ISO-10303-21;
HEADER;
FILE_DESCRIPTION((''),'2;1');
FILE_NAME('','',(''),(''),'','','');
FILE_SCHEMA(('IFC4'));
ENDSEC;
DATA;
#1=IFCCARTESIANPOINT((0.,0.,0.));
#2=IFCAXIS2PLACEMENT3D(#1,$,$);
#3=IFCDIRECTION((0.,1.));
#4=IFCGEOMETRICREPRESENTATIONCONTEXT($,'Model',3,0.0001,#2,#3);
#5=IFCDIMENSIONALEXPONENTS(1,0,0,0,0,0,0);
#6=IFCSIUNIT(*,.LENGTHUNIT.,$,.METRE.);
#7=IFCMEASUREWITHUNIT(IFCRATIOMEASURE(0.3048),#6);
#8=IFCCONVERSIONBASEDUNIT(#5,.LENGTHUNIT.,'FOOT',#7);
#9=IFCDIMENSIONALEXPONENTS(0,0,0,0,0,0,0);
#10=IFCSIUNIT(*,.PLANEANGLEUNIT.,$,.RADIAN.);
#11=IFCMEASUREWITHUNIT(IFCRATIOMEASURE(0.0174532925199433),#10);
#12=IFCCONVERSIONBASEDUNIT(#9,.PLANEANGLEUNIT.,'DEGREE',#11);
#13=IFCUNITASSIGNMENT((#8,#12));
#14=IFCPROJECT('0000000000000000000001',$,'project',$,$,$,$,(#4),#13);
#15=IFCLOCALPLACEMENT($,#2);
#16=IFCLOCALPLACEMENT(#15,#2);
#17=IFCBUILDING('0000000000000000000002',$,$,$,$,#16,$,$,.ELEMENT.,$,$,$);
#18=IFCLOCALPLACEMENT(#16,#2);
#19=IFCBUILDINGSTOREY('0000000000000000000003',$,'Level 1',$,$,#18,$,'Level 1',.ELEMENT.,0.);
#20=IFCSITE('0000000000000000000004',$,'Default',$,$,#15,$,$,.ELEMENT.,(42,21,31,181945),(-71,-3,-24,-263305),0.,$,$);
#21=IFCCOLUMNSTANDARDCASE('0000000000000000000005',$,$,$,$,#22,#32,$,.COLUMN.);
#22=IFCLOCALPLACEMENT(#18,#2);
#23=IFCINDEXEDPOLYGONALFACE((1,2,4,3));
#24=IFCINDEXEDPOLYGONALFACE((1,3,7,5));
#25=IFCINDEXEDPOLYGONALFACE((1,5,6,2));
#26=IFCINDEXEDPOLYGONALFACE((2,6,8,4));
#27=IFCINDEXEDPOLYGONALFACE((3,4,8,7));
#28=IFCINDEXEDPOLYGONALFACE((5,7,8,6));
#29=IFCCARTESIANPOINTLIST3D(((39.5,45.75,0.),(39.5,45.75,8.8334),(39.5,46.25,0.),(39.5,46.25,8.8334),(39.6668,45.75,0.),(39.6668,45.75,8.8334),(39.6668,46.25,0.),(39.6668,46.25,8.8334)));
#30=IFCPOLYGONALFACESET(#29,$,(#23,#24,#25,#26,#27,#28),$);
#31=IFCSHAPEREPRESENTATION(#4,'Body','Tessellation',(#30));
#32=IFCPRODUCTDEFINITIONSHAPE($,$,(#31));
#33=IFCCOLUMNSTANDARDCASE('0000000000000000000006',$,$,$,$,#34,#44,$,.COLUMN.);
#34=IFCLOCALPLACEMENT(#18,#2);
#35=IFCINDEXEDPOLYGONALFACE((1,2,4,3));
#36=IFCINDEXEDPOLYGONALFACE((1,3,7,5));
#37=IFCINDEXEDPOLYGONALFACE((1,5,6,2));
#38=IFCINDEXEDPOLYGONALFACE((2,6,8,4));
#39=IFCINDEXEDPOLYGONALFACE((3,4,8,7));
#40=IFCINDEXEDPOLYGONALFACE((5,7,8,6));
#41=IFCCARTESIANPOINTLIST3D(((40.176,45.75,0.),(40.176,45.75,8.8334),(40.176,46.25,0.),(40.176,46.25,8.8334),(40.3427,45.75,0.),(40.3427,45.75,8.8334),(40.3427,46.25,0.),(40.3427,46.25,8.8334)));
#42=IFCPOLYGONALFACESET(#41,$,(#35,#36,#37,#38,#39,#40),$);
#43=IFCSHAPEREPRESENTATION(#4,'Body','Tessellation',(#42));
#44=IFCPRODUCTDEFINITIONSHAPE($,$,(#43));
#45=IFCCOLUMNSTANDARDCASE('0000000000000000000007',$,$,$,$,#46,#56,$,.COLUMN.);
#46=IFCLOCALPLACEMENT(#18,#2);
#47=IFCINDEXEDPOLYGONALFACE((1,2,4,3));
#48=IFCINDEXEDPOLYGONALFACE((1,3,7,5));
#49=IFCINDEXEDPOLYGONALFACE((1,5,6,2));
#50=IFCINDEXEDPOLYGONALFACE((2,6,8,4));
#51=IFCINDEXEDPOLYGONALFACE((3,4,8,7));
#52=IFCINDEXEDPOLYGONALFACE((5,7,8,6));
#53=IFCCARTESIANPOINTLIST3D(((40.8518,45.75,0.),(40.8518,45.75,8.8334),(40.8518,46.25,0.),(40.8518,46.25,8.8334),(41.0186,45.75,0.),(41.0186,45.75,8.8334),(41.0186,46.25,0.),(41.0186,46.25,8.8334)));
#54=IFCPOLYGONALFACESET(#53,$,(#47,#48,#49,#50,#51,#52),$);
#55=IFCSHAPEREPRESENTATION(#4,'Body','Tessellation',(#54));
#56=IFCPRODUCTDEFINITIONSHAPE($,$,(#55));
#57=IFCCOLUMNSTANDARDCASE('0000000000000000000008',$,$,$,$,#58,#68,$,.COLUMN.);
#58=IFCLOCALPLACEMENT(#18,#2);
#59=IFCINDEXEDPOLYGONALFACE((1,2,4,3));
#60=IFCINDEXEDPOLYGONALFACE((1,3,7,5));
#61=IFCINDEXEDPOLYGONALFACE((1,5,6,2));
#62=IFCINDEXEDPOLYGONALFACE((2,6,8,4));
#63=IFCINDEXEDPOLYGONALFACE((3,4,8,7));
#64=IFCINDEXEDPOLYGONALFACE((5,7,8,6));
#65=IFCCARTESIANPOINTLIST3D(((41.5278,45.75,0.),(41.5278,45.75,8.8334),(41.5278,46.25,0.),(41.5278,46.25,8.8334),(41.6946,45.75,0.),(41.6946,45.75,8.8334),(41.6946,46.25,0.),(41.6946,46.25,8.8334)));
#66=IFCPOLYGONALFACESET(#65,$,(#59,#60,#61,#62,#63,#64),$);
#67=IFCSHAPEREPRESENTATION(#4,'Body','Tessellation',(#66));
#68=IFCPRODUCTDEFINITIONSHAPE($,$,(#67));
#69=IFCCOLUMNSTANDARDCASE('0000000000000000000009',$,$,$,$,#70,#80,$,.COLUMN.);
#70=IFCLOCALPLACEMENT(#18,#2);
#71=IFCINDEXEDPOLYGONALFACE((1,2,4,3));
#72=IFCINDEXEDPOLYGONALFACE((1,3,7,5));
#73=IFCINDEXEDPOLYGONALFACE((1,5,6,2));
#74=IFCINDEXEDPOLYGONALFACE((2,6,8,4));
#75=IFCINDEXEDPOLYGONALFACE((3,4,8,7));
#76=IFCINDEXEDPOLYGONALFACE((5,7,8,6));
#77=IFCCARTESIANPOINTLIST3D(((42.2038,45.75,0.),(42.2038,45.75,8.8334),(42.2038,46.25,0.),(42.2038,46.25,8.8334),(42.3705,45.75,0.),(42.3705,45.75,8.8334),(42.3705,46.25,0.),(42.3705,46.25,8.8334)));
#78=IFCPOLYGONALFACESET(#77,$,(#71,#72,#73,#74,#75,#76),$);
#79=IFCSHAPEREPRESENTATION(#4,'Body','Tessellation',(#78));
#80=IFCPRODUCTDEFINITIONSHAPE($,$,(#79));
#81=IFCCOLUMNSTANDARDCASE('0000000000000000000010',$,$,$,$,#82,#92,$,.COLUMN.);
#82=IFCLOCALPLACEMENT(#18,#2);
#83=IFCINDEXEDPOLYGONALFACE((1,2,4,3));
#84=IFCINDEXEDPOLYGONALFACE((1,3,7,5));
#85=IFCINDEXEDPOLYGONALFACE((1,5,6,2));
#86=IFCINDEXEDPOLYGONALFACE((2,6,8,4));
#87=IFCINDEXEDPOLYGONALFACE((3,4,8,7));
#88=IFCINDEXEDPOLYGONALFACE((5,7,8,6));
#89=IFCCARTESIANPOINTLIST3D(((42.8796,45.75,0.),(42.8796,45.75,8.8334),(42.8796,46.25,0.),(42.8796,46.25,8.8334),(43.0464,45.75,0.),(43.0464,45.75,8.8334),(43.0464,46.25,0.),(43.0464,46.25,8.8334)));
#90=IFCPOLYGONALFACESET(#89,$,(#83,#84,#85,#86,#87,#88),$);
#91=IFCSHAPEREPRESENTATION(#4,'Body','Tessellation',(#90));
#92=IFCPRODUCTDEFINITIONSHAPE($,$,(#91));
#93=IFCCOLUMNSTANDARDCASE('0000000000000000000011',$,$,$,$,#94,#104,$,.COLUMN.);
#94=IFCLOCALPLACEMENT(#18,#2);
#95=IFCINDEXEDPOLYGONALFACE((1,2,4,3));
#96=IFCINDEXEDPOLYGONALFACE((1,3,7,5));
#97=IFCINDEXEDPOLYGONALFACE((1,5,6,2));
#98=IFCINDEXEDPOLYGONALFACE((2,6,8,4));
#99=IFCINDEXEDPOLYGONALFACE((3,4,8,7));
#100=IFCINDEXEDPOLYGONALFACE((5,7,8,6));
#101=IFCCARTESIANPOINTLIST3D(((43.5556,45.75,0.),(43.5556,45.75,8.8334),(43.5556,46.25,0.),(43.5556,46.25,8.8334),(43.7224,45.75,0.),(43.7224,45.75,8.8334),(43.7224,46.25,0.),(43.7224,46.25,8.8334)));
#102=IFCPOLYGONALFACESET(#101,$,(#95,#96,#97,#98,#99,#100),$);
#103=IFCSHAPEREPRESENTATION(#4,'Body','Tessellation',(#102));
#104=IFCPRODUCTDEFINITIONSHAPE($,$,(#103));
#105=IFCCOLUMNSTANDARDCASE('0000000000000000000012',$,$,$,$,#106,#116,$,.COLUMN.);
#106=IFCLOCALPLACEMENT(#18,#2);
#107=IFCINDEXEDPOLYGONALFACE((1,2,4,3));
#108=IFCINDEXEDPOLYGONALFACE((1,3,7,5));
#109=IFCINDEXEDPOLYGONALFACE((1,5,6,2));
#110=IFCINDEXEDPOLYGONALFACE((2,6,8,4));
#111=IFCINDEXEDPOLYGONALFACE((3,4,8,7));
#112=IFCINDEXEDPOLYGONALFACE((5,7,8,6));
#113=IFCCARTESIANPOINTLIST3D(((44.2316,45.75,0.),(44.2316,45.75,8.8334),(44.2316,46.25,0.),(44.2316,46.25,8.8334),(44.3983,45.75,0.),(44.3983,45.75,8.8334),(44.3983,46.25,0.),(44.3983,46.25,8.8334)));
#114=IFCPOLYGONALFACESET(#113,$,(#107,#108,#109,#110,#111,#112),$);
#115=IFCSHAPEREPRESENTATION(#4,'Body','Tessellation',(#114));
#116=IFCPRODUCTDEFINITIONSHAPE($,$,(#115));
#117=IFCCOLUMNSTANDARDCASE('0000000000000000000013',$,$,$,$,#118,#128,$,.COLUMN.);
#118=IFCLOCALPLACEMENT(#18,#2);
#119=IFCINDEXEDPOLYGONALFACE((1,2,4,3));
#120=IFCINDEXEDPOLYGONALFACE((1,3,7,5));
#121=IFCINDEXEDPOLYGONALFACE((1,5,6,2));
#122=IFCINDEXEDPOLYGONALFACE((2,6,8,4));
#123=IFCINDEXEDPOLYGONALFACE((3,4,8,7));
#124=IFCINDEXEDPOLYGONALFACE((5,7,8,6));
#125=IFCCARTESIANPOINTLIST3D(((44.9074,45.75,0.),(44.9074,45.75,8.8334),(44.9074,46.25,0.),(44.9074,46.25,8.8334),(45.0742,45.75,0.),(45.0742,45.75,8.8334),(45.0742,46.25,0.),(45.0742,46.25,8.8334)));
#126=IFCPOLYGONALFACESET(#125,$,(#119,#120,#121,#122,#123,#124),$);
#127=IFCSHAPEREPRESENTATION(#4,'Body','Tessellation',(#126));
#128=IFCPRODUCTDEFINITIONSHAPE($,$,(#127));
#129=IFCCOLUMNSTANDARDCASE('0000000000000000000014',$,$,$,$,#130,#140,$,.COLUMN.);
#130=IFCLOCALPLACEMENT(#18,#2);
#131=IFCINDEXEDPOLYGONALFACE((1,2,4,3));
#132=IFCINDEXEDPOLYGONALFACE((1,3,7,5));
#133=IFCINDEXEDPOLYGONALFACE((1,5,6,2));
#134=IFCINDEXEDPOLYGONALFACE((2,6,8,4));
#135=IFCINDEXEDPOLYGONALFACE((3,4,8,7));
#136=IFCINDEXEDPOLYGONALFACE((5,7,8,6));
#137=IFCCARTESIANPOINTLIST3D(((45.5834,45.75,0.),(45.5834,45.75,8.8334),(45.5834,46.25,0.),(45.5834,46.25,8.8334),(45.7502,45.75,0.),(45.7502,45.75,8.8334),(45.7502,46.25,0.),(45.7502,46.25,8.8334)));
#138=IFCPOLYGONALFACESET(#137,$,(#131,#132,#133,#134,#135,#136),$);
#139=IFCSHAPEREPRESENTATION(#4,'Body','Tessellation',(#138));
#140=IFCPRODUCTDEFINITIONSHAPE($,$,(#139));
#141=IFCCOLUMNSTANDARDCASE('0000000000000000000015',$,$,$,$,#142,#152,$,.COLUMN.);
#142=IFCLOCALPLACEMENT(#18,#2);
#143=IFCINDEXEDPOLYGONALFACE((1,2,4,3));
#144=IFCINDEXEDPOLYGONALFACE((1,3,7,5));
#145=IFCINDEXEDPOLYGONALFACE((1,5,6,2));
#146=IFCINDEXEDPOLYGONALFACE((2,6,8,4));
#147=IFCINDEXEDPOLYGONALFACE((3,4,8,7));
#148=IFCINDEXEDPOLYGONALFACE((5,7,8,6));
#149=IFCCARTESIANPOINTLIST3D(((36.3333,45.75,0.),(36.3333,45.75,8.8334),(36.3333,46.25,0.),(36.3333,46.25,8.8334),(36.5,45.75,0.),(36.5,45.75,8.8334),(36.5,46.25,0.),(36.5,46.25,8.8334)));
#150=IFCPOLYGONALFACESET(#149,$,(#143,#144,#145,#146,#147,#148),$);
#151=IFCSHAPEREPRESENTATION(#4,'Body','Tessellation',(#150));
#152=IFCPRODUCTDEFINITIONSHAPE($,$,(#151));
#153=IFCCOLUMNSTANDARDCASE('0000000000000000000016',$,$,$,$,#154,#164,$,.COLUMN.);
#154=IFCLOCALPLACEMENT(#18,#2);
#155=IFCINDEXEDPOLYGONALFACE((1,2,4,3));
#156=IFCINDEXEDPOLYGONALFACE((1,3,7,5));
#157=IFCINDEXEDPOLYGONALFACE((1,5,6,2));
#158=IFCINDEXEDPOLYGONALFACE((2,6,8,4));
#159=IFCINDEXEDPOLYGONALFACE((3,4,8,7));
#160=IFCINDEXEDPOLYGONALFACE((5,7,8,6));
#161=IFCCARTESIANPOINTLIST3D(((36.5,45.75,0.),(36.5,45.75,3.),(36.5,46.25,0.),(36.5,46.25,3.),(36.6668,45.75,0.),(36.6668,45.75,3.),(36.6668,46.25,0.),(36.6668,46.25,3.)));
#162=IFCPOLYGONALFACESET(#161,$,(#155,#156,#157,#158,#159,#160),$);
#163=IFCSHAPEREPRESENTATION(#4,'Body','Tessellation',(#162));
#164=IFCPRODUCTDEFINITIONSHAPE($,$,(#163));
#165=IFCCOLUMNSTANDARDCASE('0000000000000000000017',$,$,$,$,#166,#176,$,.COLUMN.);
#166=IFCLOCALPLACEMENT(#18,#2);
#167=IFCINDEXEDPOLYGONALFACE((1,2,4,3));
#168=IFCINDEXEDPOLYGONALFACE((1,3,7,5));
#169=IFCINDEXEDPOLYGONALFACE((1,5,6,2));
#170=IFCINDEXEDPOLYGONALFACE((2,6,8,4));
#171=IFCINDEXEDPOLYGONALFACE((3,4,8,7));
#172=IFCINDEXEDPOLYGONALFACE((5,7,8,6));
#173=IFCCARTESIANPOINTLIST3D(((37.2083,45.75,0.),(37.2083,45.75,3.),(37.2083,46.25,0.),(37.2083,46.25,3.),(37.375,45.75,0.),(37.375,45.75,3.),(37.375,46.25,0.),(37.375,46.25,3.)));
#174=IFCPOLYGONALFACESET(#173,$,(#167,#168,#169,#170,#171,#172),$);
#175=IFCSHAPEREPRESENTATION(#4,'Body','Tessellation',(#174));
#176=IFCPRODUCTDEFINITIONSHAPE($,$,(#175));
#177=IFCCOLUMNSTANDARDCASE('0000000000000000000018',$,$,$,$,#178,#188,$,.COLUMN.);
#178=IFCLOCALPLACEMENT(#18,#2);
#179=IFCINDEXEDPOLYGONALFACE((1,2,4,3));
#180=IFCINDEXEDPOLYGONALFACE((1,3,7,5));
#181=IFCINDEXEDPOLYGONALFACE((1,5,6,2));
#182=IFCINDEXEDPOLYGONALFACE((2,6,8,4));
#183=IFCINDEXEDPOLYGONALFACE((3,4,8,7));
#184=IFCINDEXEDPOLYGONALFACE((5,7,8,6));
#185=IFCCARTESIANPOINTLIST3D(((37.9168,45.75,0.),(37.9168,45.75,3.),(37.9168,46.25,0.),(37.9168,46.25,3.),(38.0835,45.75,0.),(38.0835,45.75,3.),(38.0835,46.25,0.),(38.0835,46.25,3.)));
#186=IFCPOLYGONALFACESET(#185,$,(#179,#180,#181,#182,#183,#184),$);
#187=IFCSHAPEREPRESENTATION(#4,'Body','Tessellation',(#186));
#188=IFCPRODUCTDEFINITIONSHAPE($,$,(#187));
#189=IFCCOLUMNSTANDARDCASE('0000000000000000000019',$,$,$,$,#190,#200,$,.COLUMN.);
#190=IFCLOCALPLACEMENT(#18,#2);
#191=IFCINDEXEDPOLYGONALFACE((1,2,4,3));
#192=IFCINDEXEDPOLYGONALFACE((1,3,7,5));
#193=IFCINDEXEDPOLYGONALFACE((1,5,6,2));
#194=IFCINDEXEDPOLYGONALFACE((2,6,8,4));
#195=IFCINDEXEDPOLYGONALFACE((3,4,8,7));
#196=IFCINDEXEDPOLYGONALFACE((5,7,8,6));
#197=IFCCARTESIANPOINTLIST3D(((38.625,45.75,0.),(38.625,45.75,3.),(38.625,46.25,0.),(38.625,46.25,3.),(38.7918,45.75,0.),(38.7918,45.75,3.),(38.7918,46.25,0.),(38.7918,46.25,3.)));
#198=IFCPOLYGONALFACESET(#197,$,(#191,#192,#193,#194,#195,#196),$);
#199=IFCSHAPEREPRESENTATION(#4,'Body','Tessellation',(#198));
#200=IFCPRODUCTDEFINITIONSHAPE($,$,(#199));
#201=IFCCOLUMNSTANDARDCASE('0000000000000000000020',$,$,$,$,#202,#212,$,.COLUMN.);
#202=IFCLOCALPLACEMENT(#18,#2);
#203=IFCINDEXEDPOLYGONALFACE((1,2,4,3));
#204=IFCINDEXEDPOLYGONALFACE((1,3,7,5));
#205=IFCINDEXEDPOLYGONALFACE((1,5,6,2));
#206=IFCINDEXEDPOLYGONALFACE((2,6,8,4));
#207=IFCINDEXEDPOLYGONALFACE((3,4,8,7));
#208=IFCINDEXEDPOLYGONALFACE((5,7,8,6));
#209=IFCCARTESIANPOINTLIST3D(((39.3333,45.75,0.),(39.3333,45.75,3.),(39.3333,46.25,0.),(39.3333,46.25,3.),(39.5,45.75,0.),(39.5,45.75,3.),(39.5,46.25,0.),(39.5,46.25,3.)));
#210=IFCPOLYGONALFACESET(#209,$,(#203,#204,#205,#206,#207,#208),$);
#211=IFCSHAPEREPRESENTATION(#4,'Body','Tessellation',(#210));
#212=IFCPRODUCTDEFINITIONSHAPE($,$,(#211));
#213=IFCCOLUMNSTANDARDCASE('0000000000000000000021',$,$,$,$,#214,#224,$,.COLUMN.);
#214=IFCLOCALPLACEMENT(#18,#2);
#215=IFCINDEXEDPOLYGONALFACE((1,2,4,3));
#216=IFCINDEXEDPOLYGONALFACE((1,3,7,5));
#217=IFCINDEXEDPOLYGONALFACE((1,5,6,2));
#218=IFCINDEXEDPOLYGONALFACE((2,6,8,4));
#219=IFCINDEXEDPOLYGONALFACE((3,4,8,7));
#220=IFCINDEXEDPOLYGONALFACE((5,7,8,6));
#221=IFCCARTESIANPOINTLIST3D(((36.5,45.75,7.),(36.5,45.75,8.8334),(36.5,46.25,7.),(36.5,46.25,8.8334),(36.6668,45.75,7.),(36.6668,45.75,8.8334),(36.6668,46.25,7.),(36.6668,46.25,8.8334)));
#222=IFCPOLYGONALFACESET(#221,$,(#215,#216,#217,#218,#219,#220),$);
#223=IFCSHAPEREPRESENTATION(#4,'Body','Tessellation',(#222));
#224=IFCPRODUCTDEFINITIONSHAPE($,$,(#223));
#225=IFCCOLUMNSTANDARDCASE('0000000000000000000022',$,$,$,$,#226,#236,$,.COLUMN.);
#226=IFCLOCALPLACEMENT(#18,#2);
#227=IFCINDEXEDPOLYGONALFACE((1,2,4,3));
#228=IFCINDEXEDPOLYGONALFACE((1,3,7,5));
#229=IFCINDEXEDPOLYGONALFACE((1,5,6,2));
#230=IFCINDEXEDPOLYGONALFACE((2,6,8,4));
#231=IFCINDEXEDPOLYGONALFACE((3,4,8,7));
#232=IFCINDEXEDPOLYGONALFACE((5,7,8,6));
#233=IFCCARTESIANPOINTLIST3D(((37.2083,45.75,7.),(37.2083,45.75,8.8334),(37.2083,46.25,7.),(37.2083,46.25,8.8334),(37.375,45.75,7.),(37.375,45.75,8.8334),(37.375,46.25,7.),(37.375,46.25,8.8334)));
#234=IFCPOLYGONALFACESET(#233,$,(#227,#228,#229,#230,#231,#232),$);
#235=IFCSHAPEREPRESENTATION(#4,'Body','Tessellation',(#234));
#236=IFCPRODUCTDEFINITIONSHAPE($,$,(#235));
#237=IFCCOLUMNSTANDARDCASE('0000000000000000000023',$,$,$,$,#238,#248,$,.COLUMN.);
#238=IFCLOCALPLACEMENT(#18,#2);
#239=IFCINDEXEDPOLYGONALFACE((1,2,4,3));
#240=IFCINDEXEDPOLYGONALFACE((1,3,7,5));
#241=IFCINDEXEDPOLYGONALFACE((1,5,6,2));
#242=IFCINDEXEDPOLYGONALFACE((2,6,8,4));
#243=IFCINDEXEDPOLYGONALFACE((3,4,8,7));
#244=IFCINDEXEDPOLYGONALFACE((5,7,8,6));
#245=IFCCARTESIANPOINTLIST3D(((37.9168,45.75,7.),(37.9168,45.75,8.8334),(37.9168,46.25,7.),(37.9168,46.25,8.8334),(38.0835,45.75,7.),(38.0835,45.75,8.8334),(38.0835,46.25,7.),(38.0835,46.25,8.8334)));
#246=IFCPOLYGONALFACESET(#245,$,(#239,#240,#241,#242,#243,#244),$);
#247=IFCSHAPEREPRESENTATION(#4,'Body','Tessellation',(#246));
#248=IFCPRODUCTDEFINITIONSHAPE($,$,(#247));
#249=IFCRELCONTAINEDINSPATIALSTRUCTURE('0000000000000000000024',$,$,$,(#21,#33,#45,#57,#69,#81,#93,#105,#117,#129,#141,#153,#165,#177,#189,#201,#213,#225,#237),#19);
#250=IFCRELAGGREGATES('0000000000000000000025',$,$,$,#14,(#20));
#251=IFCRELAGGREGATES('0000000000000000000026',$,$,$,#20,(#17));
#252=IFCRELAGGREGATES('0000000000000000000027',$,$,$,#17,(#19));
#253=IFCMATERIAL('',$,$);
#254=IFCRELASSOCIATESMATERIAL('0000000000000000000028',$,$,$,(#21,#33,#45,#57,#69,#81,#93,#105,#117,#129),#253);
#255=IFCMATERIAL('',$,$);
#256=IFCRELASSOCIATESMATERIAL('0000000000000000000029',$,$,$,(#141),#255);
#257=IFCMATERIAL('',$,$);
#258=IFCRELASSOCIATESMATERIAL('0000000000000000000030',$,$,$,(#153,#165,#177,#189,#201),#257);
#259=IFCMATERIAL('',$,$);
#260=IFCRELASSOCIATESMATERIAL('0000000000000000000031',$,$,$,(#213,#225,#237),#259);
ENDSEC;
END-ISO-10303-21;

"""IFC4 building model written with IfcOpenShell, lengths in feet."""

from ifc_helpers import new_model, entity, si_unit, converted_unit, direction, frame, origin, place, context, project, spatial, rectangle, extrude, material, element, save


model = new_model("IFC4")

# Units and contexts
model_context = context("Model", 3, precision=0.0001, world=origin(), true_north=direction((0.0, 1.0)))
ifc_project = project(units=[converted_unit("LENGTHUNIT", "FOOT", entity("IfcRatioMeasure", 0.3048), si_unit("LENGTHUNIT", "METRE"), dimensions=[1, 0, 0, 0, 0, 0, 0]), converted_unit("PLANEANGLEUNIT", "DEGREE", entity("IfcRatioMeasure", 0.0174532925199433), si_unit("PLANEANGLEUNIT", "RADIAN"), dimensions=[0, 0, 0, 0, 0, 0, 0])], contexts=[model_context])

# Site, building, storey
site_placement = place(None, origin())
site = spatial("IfcSite", under=ifc_project, at=site_placement, Name="Default", CompositionType="ELEMENT", RefLatitude=(42, 21, 31, 181945), RefLongitude=(-71, -3, -24, -263305), RefElevation=0.0)
building_placement = place(site_placement, origin())
building = spatial("IfcBuilding", under=site, at=building_placement, CompositionType="ELEMENT")
storey_placement = place(building_placement, origin())
storey = spatial("IfcBuildingStorey", under=building, at=storey_placement, Name="Level 1", LongName="Level 1", CompositionType="ELEMENT", Elevation=0.0)

# Columns
ifc_material_1 = material(Name="")
placement_1 = place(storey_placement, frame((-0.25, 46.0, 0.0)))
for number, where, z_axis, x_axis in (
    (1, (39.8334, 0.0, 0.0), (0.0, 0.0, 1.0), (1.0, 0.0, 0.0)),
    (2, (40.5093, 0.0, 0.0), (0.0, 0.0, 1.0), (1.0, 0.0, 0.0)),
    (3, (41.1852, 0.0, 0.0), (0.0, 0.0, 1.0), (1.0, 0.0, 0.0)),
    (4, (41.8612, 0.0, 0.0), (0.0, 0.0, 1.0), (1.0, 0.0, 0.0)),
    (5, (42.5371, 0.0, 0.0), (0.0, 0.0, 1.0), (1.0, 0.0, 0.0)),
    (6, (43.213, 0.0, 0.0), (0.0, 0.0, 1.0), (1.0, 0.0, 0.0)),
    (7, (43.889, 0.0, 0.0), (0.0, 0.0, 1.0), (1.0, 0.0, 0.0)),
    (8, (44.5649, 0.0, 0.0), (0.0, 0.0, 1.0), (1.0, 0.0, 0.0)),
    (9, (45.2408, 0.0, 0.0), (0.0, 0.0, 1.0), (1.0, 0.0, 0.0)),
    (10, (45.9168, 0.0, 0.0), (0.0, 0.0, 1.0), (1.0, 0.0, 0.0)),
):
    element("IfcColumnStandardCase", number, at=place(placement_1, frame(where, z_axis=z_axis, x_axis=x_axis)), inside=storey, material=ifc_material_1, PredefinedType="COLUMN", context=model_context, shape_type="SweptSolid", body=[
        extrude(rectangle(XDim=0.1667, YDim=0.5), origin(), (0.0, 0.0, 1.0), 8.8334),
    ])
ifc_material_2 = material(Name="")
column_placement = place(placement_1, frame((36.6667, 0.0, 0.0), z_axis=(0.0, 0.0, 1.0), x_axis=(1.0, 0.0, 0.0)))
element("IfcColumnStandardCase", 11, at=column_placement, inside=storey, material=ifc_material_2, PredefinedType="COLUMN", context=model_context, shape_type="SweptSolid", body=[
    extrude(rectangle(XDim=0.1667, YDim=0.5), origin(), (0.0, 0.0, 1.0), 8.8334),
])
ifc_material_3 = material(Name="")
for number, where, z_axis, x_axis in (
    (12, (36.8334, 0.0, 0.0), (0.0, 0.0, 1.0), (1.0, 0.0, 0.0)),
    (13, (37.5417, 0.0, 0.0), (0.0, 0.0, 1.0), (1.0, 0.0, 0.0)),
    (14, (38.2501, 0.0, 0.0), (0.0, 0.0, 1.0), (1.0, 0.0, 0.0)),
    (15, (38.9584, 0.0, 0.0), (0.0, 0.0, 1.0), (1.0, 0.0, 0.0)),
    (16, (39.6667, 0.0, 0.0), (0.0, 0.0, 1.0), (1.0, 0.0, 0.0)),
):
    element("IfcColumnStandardCase", number, at=place(placement_1, frame(where, z_axis=z_axis, x_axis=x_axis)), inside=storey, material=ifc_material_3, PredefinedType="COLUMN", context=model_context, shape_type="SweptSolid", body=[
        extrude(rectangle(XDim=0.1667, YDim=0.5), origin(), (0.0, 0.0, 1.0), 3.0),
    ])
ifc_material_4 = material(Name="")
for number, where, z_axis, x_axis in (
    (17, (36.8334, 0.0, 7.0), (0.0, 0.0, 1.0), (1.0, 0.0, 0.0)),
    (18, (37.5417, 0.0, 7.0), (0.0, 0.0, 1.0), (1.0, 0.0, 0.0)),
    (19, (38.2501, 0.0, 7.0), (0.0, 0.0, 1.0), (1.0, 0.0, 0.0)),
):
    element("IfcColumnStandardCase", number, at=place(placement_1, frame(where, z_axis=z_axis, x_axis=x_axis)), inside=storey, material=ifc_material_4, PredefinedType="COLUMN", context=model_context, shape_type="SweptSolid", body=[
        extrude(rectangle(XDim=0.1667, YDim=0.5), origin(), (0.0, 0.0, 1.0), 1.8334),
    ])

save(model, "model.ifc")
